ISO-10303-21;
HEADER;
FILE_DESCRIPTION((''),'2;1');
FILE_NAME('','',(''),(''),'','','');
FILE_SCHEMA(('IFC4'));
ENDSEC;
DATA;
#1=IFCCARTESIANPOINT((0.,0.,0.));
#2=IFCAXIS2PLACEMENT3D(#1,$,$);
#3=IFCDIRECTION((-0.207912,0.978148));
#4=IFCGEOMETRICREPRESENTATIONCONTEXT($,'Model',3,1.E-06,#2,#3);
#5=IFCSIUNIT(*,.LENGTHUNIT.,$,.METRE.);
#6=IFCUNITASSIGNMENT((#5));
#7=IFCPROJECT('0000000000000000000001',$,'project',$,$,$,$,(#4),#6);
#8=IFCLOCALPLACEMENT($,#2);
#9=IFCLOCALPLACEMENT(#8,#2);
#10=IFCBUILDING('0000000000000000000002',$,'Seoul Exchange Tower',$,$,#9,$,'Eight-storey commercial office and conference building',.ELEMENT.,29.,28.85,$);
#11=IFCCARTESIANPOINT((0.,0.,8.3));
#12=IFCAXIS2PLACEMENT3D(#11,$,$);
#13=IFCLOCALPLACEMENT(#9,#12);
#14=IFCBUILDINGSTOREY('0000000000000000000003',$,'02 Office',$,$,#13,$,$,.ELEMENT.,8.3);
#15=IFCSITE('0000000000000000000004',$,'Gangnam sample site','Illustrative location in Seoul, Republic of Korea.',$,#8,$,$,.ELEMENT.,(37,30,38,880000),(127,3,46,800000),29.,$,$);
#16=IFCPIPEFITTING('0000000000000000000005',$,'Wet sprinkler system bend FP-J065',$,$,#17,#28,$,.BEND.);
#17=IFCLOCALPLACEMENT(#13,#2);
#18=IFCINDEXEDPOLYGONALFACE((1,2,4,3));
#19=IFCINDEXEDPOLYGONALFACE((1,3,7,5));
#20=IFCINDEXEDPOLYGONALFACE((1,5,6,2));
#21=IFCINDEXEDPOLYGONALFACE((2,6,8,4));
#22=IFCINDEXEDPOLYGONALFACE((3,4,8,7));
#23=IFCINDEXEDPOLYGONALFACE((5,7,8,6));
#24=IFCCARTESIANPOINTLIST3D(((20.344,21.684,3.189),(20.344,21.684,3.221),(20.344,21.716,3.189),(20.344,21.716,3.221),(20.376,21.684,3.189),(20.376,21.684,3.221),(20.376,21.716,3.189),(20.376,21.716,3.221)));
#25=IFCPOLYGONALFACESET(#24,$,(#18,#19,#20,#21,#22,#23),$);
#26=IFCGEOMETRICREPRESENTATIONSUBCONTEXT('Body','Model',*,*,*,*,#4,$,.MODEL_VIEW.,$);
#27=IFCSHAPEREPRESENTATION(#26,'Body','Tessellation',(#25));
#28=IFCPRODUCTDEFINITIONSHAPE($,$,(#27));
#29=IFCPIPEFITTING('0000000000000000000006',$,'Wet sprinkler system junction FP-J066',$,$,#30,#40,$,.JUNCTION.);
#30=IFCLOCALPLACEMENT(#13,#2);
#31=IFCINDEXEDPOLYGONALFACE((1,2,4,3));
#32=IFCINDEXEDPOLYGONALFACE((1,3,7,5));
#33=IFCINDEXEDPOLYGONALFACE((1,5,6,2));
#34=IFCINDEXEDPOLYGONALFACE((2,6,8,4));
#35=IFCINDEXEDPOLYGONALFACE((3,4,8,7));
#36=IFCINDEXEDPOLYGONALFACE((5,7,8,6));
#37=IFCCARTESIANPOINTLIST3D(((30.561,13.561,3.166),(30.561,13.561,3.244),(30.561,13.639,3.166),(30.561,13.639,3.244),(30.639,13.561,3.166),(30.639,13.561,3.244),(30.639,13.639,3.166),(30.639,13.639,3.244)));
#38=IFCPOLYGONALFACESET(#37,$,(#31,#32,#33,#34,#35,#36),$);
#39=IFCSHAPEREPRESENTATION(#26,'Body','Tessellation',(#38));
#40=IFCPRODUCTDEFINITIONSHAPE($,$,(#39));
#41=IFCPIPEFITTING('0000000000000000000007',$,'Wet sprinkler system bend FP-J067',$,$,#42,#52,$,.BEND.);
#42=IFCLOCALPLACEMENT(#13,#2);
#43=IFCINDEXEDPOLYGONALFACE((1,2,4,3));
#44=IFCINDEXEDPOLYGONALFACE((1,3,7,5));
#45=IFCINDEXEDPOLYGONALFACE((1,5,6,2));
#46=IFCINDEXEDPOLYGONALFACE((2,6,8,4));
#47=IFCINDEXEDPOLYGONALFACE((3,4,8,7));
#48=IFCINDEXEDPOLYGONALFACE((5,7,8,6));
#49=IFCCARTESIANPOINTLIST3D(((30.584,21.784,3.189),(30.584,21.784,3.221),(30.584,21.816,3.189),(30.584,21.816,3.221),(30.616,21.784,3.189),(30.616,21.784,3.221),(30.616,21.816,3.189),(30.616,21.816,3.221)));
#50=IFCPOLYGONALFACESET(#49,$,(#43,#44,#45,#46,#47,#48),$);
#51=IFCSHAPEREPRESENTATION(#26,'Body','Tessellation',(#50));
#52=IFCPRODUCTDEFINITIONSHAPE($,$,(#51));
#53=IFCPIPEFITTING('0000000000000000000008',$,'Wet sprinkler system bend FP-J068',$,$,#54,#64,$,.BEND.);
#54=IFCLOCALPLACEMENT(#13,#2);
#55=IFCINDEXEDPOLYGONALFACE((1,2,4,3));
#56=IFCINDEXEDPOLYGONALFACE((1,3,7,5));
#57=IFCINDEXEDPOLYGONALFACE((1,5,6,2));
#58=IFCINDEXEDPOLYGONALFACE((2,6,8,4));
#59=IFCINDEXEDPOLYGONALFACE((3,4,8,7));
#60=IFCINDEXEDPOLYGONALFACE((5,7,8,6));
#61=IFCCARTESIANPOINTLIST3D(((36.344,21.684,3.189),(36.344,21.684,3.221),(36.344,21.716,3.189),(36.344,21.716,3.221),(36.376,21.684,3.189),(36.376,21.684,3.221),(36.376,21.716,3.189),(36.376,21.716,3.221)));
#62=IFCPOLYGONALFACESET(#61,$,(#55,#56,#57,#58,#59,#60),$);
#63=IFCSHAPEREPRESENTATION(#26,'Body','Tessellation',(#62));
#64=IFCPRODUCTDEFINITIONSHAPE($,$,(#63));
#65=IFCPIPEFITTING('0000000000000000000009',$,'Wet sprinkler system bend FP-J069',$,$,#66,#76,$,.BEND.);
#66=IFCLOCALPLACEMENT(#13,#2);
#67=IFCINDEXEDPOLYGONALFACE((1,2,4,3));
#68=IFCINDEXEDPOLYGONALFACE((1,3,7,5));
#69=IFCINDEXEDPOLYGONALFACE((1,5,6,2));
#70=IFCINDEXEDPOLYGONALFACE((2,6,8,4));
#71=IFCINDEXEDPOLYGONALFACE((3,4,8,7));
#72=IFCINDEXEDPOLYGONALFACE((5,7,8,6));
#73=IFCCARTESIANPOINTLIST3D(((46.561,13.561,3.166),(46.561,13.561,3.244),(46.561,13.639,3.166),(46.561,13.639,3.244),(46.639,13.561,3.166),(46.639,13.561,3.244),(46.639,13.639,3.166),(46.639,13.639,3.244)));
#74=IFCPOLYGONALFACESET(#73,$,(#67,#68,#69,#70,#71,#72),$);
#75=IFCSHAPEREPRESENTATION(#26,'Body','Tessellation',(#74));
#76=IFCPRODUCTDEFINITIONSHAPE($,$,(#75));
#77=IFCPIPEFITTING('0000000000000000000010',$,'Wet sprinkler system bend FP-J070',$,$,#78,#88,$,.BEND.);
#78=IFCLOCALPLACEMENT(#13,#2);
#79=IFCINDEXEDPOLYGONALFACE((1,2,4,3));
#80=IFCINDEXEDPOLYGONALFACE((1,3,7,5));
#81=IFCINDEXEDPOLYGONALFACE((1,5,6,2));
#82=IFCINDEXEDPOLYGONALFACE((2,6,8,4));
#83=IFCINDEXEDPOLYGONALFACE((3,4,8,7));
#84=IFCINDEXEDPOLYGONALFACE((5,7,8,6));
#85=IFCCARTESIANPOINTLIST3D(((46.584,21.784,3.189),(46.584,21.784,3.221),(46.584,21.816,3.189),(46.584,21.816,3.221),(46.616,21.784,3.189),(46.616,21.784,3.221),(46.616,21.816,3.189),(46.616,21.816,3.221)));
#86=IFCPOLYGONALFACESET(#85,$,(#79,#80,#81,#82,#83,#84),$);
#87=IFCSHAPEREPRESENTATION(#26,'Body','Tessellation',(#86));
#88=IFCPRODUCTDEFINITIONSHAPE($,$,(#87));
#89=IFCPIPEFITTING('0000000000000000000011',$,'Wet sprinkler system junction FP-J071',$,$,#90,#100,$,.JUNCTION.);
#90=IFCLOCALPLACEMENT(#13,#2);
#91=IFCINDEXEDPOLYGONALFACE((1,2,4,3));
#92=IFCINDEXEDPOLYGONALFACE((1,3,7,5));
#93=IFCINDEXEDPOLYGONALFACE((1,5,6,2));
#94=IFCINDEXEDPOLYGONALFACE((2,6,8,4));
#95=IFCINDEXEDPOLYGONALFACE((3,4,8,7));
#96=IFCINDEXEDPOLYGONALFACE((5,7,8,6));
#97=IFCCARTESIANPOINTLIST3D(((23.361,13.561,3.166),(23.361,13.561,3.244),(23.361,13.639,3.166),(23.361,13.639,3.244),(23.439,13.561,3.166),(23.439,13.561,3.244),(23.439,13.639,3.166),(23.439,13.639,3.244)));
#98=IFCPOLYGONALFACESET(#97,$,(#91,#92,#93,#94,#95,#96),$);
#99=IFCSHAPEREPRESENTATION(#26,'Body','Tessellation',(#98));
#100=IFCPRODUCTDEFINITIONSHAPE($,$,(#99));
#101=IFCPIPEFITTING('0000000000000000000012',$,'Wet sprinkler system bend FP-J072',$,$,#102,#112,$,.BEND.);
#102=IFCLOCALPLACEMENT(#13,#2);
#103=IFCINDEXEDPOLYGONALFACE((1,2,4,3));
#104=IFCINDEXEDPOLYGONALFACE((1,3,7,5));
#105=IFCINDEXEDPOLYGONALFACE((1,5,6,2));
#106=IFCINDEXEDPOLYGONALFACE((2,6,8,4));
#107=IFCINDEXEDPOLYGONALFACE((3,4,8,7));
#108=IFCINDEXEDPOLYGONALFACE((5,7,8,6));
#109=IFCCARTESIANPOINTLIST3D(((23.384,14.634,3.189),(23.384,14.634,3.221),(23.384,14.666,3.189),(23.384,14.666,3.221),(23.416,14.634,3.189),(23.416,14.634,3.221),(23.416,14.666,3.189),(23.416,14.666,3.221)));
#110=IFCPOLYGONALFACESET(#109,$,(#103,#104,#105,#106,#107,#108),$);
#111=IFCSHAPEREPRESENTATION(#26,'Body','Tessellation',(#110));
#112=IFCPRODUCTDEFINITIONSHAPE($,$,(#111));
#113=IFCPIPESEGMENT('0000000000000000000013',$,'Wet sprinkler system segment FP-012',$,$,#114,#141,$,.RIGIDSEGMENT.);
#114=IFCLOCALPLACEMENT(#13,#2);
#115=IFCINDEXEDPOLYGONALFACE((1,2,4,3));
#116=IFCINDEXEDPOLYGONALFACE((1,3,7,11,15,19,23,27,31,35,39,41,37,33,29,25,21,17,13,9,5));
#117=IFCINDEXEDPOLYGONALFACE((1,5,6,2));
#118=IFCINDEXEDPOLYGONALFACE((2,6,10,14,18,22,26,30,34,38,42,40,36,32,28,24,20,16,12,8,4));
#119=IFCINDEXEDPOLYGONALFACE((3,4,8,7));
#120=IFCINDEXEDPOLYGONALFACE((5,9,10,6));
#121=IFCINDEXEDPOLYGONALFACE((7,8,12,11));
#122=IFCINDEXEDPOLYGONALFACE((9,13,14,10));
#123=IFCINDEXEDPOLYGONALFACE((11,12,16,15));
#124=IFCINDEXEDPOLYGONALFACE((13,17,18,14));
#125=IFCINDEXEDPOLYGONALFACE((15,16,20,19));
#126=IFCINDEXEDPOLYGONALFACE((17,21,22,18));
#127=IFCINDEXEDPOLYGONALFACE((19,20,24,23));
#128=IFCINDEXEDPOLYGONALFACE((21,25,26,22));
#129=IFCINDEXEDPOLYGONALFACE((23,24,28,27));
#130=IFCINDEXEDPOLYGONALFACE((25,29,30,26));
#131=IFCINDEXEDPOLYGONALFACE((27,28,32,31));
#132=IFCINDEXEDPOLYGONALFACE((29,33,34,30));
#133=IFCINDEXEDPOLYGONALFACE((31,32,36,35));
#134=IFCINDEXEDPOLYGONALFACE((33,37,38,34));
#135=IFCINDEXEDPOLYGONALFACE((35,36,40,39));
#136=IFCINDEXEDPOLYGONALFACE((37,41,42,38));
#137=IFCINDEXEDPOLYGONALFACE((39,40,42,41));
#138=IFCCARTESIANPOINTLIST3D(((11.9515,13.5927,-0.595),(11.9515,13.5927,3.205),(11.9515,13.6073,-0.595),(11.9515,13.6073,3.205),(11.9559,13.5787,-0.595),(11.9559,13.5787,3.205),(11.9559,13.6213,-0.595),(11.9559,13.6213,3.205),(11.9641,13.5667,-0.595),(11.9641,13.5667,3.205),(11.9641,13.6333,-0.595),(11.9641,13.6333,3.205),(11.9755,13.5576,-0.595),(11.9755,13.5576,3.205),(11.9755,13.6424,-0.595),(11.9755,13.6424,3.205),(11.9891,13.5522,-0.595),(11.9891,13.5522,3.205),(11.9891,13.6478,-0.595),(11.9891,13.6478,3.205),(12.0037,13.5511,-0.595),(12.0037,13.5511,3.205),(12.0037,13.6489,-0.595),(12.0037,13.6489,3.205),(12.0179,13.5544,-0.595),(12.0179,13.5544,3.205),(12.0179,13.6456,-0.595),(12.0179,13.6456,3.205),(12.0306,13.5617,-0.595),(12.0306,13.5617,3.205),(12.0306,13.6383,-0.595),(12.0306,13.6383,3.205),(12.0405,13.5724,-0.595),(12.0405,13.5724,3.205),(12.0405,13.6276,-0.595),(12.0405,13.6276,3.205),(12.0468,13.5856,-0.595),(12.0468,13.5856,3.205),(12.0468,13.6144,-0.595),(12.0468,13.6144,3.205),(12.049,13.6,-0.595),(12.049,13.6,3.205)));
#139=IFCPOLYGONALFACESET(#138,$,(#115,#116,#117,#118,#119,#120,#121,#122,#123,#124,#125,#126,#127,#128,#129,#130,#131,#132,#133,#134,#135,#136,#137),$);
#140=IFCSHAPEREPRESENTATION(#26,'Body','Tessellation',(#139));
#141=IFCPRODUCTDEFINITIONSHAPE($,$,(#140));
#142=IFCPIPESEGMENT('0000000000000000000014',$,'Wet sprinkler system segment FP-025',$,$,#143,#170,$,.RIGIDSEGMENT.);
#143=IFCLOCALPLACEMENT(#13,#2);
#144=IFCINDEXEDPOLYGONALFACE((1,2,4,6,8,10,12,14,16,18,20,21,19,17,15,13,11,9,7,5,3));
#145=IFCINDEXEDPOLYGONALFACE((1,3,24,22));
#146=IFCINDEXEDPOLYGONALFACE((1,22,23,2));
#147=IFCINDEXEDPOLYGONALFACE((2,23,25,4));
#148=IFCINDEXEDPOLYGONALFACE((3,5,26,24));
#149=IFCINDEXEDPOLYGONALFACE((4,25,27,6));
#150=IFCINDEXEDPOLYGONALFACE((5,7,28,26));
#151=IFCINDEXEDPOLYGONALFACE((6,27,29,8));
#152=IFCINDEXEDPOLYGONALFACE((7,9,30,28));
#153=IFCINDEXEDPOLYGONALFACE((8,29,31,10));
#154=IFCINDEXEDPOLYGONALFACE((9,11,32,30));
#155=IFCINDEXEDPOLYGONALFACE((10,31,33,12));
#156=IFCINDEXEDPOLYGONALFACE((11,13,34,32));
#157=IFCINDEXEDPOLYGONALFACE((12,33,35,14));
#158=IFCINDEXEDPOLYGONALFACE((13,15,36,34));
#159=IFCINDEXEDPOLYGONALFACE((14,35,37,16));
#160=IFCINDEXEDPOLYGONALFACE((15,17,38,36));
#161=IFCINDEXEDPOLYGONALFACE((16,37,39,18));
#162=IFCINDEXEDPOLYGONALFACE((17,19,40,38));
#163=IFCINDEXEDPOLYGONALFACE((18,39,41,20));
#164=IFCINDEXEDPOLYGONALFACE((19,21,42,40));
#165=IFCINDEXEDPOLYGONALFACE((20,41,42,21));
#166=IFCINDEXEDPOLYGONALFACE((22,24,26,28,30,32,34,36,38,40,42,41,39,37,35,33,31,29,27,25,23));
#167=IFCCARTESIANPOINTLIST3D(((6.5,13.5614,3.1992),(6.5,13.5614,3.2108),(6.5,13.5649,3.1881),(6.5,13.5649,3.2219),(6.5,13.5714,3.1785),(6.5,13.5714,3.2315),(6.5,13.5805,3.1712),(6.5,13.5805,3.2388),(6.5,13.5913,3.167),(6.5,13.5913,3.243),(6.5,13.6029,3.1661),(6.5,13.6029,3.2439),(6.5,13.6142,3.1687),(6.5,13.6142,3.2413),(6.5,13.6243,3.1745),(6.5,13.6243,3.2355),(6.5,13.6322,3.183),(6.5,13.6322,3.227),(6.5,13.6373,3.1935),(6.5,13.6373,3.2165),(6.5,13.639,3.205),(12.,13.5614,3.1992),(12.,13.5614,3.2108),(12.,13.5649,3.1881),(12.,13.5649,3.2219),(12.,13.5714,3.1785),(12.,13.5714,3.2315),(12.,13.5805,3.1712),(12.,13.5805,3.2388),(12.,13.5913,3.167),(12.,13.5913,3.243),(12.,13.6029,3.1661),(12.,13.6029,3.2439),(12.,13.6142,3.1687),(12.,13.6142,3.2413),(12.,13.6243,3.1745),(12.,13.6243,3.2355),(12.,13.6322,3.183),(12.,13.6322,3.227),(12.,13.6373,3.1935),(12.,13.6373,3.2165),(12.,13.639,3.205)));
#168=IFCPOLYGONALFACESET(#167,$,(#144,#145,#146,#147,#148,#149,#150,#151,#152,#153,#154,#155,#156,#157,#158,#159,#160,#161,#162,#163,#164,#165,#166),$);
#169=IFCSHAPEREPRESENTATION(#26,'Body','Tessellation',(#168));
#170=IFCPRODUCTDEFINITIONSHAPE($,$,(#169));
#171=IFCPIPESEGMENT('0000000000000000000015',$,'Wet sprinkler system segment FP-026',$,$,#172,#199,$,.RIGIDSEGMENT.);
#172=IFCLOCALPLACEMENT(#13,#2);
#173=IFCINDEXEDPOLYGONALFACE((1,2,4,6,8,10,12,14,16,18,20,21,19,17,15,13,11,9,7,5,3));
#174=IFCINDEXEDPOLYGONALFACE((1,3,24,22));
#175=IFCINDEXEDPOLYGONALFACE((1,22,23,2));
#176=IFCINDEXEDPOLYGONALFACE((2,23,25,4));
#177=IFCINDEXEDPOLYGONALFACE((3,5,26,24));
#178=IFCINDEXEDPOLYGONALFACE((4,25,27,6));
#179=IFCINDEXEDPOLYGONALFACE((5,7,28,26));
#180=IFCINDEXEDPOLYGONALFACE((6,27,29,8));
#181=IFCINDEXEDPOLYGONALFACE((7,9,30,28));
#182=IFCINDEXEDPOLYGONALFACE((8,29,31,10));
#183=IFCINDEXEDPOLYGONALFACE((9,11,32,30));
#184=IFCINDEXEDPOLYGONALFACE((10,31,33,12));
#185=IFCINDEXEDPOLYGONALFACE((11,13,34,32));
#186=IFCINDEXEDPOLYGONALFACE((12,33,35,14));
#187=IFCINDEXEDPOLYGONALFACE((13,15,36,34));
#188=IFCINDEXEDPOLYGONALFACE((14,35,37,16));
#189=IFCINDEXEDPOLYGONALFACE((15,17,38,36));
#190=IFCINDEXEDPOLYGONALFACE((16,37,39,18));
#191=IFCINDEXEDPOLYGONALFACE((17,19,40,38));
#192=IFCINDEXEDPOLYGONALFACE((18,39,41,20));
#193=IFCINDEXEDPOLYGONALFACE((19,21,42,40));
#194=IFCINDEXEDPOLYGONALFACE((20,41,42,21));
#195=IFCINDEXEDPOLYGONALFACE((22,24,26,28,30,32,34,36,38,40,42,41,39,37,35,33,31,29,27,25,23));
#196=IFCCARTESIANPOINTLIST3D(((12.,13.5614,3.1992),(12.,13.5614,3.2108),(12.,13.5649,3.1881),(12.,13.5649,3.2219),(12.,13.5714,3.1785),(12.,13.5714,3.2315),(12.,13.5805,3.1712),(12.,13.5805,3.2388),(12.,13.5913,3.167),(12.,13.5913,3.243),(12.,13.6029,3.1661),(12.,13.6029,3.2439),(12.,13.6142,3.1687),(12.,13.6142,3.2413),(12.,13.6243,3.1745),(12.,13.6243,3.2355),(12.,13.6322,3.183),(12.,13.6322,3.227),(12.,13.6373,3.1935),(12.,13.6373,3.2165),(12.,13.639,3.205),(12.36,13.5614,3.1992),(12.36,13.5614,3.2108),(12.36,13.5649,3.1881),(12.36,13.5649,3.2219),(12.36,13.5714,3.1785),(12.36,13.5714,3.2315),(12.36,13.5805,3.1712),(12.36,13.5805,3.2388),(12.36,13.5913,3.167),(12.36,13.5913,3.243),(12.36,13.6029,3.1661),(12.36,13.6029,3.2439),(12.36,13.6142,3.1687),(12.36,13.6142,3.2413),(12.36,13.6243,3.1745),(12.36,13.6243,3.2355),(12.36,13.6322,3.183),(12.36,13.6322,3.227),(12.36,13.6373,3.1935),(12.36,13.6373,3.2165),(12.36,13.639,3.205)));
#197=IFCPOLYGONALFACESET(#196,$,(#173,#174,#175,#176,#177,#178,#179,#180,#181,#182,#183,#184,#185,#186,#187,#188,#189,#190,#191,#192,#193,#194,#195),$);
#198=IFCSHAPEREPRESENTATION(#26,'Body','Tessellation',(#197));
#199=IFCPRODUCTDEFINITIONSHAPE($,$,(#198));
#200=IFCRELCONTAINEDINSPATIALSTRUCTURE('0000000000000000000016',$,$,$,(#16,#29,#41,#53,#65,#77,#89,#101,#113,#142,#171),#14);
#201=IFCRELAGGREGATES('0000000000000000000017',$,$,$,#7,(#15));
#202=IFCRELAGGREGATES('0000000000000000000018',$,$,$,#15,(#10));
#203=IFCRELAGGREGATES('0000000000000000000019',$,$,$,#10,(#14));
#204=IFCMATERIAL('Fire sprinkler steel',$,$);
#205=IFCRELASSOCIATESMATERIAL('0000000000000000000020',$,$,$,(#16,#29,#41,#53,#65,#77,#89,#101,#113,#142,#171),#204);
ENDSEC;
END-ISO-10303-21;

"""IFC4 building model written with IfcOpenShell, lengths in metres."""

from ifc_helpers import new_model, si_unit, direction, frame, frame_2d, origin, place, context, subcontext, project, spatial, rectangle, circle, extrude, material, element, save


model = new_model("IFC4")

# Units and contexts
model_context = context("Model", 3, precision=1e-06, world=origin(), true_north=direction((-0.207912, 0.978148)))
body_context = subcontext(model_context, "Body", "Model", "MODEL_VIEW")
ifc_project = project(units=[si_unit("LENGTHUNIT", "METRE")], contexts=[model_context])

# Site, building, storey
site_placement = place(None, origin())
site = spatial("IfcSite", under=ifc_project, at=site_placement, Name="Gangnam sample site", Description="Illustrative location in Seoul, Republic of Korea.", CompositionType="ELEMENT", RefLatitude=(37, 30, 38, 880000), RefLongitude=(127, 3, 46, 800000), RefElevation=29.0)
building_placement = place(site_placement, origin())
building = spatial("IfcBuilding", under=site, at=building_placement, Name="Seoul Exchange Tower", LongName="Eight-storey commercial office and conference building", CompositionType="ELEMENT", ElevationOfRefHeight=29.0, ElevationOfTerrain=28.85)
storey_placement = place(building_placement, frame((0.0, 0.0, 8.3)))
storey = spatial("IfcBuildingStorey", under=building, at=storey_placement, Name="02 Office", CompositionType="ELEMENT", Elevation=8.3)

# Pipe fittings
ifc_material = material(Name="Fire sprinkler steel")
placement = place(storey_placement, origin())
element("IfcPipeFitting", 1, at=placement, inside=storey, material=ifc_material, Name="Wet sprinkler system bend FP-J065", PredefinedType="BEND", context=body_context, shape_type="SweptSolid", body=[
    extrude(rectangle(XDim=0.032, YDim=0.032, at=frame_2d((0.016, 0.016))), frame((20.344, 21.684, 3.189)), (0.0, 0.0, 1.0), 0.032),
])
element("IfcPipeFitting", 2, at=placement, inside=storey, material=ifc_material, Name="Wet sprinkler system junction FP-J066", PredefinedType="JUNCTION", context=body_context, shape_type="SweptSolid", body=[
    extrude(rectangle(XDim=0.078, YDim=0.078, at=frame_2d((0.039, 0.039))), frame((30.561, 13.561, 3.166)), (0.0, 0.0, 1.0), 0.078),
])
element("IfcPipeFitting", 3, at=placement, inside=storey, material=ifc_material, Name="Wet sprinkler system bend FP-J067", PredefinedType="BEND", context=body_context, shape_type="SweptSolid", body=[
    extrude(rectangle(XDim=0.032, YDim=0.032, at=frame_2d((0.016, 0.016))), frame((30.584, 21.784, 3.189)), (0.0, 0.0, 1.0), 0.032),
])
element("IfcPipeFitting", 4, at=placement, inside=storey, material=ifc_material, Name="Wet sprinkler system bend FP-J068", PredefinedType="BEND", context=body_context, shape_type="SweptSolid", body=[
    extrude(rectangle(XDim=0.032, YDim=0.032, at=frame_2d((0.016, 0.016))), frame((36.344, 21.684, 3.189)), (0.0, 0.0, 1.0), 0.032),
])
element("IfcPipeFitting", 5, at=placement, inside=storey, material=ifc_material, Name="Wet sprinkler system bend FP-J069", PredefinedType="BEND", context=body_context, shape_type="SweptSolid", body=[
    extrude(rectangle(XDim=0.078, YDim=0.078, at=frame_2d((0.039, 0.039))), frame((46.561, 13.561, 3.166)), (0.0, 0.0, 1.0), 0.078),
])
element("IfcPipeFitting", 6, at=placement, inside=storey, material=ifc_material, Name="Wet sprinkler system bend FP-J070", PredefinedType="BEND", context=body_context, shape_type="SweptSolid", body=[
    extrude(rectangle(XDim=0.032, YDim=0.032, at=frame_2d((0.016, 0.016))), frame((46.584, 21.784, 3.189)), (0.0, 0.0, 1.0), 0.032),
])
element("IfcPipeFitting", 7, at=placement, inside=storey, material=ifc_material, Name="Wet sprinkler system junction FP-J071", PredefinedType="JUNCTION", context=body_context, shape_type="SweptSolid", body=[
    extrude(rectangle(XDim=0.078, YDim=0.078, at=frame_2d((0.039, 0.039))), frame((23.361, 13.561, 3.166)), (0.0, 0.0, 1.0), 0.078),
])
element("IfcPipeFitting", 8, at=placement, inside=storey, material=ifc_material, Name="Wet sprinkler system bend FP-J072", PredefinedType="BEND", context=body_context, shape_type="SweptSolid", body=[
    extrude(rectangle(XDim=0.032, YDim=0.032, at=frame_2d((0.016, 0.016))), frame((23.384, 14.634, 3.189)), (0.0, 0.0, 1.0), 0.032),
])

# Pipe segments
element("IfcPipeSegment", 9, at=placement, inside=storey, material=ifc_material, Name="Wet sprinkler system segment FP-012", PredefinedType="RIGIDSEGMENT", context=body_context, shape_type="SweptSolid", body=[
    extrude(circle(Radius=0.049), frame((12.0, 13.6, -0.595), z_axis=(0.0, 0.0, 1.0), x_axis=(1.0, 0.0, 0.0)), (0.0, 0.0, 1.0), 3.8),
])
element("IfcPipeSegment", 10, at=placement, inside=storey, material=ifc_material, Name="Wet sprinkler system segment FP-025", PredefinedType="RIGIDSEGMENT", context=body_context, shape_type="SweptSolid", body=[
    extrude(circle(Radius=0.039), frame((12.0, 13.6, 3.205), z_axis=(-1.0, 0.0, 0.0), x_axis=(0.0, 1.0, 0.0)), (0.0, 0.0, 1.0), 5.5),
])
element("IfcPipeSegment", 11, at=placement, inside=storey, material=ifc_material, Name="Wet sprinkler system segment FP-026", PredefinedType="RIGIDSEGMENT", context=body_context, shape_type="SweptSolid", body=[
    extrude(circle(Radius=0.039), frame((12.0, 13.6, 3.205), z_axis=(1.0, 0.0, 0.0), x_axis=(0.0, 1.0, 0.0)), (0.0, 0.0, 1.0), 0.36),
])

save(model, "model.ifc")
